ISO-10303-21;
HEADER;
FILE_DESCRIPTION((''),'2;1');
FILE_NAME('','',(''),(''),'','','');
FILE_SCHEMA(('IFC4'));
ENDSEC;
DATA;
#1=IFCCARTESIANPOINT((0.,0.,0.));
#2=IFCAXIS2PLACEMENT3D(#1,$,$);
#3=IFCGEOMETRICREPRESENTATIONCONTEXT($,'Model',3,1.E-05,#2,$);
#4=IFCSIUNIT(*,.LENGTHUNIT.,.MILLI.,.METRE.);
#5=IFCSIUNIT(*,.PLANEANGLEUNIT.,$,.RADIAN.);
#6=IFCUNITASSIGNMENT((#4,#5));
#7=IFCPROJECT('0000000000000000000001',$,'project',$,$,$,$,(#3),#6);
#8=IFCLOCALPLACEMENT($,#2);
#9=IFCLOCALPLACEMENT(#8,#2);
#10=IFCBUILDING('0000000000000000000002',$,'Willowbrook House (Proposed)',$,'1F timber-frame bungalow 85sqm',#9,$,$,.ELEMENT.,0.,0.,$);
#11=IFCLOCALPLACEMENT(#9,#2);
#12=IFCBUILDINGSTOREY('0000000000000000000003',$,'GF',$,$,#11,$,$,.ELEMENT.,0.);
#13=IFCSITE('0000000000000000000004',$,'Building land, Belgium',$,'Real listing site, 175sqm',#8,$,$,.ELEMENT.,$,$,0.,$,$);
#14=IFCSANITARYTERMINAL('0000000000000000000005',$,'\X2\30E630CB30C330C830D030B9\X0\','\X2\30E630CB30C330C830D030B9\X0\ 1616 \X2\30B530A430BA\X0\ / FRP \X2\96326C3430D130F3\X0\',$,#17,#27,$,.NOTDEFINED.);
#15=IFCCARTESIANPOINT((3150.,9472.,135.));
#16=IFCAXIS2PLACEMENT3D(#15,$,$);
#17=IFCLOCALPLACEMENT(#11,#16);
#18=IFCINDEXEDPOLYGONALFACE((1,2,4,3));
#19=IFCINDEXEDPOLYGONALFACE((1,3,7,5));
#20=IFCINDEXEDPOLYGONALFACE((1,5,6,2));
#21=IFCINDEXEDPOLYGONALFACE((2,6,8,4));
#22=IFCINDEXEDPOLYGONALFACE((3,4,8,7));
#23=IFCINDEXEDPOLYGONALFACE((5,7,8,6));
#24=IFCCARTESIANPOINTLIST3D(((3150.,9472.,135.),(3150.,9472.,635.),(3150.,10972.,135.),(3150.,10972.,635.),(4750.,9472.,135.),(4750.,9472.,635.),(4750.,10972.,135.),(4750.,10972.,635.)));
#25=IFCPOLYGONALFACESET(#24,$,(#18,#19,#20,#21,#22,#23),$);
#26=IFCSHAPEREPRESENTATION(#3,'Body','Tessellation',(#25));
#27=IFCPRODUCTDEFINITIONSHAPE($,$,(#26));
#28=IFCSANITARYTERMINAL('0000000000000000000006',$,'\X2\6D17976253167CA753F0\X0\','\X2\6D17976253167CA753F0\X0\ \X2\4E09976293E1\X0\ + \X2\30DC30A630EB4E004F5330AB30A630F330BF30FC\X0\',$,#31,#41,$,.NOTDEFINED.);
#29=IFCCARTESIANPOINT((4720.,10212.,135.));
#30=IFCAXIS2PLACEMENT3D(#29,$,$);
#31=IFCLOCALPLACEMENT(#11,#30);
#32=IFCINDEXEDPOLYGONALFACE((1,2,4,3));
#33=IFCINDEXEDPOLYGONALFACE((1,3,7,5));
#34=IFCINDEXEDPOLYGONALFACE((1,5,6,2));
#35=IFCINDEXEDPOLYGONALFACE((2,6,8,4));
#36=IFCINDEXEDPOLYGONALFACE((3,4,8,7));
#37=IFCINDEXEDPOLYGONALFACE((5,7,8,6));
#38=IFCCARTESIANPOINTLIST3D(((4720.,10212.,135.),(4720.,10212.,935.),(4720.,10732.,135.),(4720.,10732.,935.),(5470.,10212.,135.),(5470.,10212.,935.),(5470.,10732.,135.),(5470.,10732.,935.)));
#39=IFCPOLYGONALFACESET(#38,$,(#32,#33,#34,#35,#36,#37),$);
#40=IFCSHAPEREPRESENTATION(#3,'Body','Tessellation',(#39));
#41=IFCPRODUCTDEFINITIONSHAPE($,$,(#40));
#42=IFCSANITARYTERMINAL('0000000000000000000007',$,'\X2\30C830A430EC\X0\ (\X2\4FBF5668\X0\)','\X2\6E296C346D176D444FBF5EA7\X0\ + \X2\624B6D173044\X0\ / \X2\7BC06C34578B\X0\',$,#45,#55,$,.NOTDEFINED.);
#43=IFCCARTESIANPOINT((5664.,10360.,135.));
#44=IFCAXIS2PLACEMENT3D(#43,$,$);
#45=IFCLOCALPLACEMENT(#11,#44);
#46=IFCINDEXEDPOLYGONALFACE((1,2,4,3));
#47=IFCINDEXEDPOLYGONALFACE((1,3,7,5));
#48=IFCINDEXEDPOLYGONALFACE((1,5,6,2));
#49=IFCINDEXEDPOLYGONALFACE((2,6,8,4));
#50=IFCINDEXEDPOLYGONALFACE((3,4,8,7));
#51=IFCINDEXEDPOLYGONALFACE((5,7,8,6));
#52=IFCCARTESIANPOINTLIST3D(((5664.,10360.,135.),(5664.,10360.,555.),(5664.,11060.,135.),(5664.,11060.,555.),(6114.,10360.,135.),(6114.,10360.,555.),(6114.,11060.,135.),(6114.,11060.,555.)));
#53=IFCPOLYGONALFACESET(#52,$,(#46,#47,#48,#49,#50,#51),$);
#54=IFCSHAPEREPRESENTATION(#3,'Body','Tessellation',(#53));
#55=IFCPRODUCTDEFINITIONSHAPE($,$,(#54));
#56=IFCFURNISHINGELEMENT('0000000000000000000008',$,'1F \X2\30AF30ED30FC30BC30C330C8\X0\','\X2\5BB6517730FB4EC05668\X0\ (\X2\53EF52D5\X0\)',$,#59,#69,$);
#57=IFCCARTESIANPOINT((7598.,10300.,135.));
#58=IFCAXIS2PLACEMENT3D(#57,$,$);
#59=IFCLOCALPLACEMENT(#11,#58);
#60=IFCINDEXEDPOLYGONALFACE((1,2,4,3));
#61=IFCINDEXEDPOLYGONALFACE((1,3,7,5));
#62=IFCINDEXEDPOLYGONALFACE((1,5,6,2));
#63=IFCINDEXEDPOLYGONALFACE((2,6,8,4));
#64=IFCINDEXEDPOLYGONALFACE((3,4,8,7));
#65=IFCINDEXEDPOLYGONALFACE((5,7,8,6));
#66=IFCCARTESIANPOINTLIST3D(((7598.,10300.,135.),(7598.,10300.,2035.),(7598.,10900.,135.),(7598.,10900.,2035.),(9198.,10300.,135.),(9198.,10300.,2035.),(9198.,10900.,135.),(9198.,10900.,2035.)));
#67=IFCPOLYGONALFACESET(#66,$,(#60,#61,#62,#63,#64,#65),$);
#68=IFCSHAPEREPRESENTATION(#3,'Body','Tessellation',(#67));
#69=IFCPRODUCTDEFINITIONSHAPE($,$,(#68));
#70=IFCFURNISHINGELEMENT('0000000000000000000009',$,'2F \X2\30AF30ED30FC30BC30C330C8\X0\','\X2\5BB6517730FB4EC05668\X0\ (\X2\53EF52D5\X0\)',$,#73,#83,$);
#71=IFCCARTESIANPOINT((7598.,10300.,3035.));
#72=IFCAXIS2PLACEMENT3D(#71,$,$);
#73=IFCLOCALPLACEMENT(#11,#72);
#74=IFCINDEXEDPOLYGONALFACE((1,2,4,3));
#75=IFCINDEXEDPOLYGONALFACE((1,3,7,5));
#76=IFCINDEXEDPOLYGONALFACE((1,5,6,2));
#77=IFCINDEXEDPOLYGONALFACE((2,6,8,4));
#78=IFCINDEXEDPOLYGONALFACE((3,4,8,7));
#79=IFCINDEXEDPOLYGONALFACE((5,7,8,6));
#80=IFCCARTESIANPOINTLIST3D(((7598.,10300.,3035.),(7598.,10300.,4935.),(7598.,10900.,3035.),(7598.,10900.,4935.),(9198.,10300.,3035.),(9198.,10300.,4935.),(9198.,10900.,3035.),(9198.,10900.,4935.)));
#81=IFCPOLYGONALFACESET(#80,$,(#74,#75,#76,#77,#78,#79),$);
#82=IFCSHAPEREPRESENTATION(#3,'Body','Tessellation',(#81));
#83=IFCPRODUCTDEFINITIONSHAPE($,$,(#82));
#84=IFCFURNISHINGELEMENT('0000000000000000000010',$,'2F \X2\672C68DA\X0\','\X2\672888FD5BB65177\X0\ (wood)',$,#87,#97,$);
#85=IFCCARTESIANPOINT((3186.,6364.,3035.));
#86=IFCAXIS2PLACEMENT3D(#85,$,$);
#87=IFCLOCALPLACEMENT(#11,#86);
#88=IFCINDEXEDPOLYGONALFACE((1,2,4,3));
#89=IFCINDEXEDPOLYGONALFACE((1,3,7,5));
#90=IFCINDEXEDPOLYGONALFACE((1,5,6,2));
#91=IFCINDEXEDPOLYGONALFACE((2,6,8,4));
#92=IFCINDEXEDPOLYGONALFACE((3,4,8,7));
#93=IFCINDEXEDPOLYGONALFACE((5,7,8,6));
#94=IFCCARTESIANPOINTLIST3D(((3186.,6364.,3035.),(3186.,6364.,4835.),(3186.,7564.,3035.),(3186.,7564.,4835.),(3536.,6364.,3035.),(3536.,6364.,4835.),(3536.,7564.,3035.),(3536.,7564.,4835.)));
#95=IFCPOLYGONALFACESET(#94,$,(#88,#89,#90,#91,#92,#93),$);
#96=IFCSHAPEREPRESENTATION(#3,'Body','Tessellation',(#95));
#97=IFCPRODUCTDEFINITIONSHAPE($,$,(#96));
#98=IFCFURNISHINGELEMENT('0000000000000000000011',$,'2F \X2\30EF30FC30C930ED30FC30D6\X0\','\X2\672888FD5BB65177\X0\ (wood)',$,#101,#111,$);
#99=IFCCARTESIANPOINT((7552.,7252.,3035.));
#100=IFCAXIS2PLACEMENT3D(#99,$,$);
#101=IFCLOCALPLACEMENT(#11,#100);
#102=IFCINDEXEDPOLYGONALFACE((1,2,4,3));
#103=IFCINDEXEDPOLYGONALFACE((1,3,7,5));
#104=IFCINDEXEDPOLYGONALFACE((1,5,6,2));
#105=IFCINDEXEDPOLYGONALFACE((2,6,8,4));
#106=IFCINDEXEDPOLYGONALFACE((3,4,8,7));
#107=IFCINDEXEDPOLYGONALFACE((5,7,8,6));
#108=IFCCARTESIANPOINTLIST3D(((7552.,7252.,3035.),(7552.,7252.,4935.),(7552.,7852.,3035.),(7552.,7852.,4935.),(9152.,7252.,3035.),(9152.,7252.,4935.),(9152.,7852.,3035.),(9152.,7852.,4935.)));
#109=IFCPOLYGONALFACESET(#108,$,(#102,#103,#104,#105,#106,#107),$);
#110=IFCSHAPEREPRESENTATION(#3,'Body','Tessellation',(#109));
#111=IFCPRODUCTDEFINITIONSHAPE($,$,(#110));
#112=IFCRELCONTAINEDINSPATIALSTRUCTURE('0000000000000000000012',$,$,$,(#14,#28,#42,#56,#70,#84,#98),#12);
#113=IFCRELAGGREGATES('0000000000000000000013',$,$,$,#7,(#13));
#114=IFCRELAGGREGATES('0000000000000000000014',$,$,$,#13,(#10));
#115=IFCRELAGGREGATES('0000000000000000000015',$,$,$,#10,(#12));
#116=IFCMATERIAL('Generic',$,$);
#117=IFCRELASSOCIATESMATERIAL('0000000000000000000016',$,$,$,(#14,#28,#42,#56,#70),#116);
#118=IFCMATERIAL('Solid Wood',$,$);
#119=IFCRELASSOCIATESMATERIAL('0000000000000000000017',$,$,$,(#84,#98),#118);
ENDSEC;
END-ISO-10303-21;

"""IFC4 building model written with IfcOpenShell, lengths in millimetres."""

from ifc_helpers import new_model, si_unit, frame, frame_2d, origin, place, context, project, spatial, rectangle, extrude, material, element, save


model = new_model("IFC4")

# Units and contexts
model_context = context("Model", 3, precision=1e-05, world=origin())
ifc_project = project(units=[si_unit("LENGTHUNIT", "METRE", prefix="MILLI"), si_unit("PLANEANGLEUNIT", "RADIAN")], contexts=[model_context])

# Site, building, storey
site_placement = place(None, origin())
site = spatial("IfcSite", under=ifc_project, at=site_placement, Name="Building land, Belgium", ObjectType="Real listing site, 175sqm", CompositionType="ELEMENT", RefElevation=0.0)
building_placement = place(site_placement, origin())
building = spatial("IfcBuilding", under=site, at=building_placement, Name="Willowbrook House (Proposed)", ObjectType="1F timber-frame bungalow 85sqm", CompositionType="ELEMENT", ElevationOfRefHeight=0.0, ElevationOfTerrain=0.0)
storey_placement = place(building_placement, origin())
storey = spatial("IfcBuildingStorey", under=building, at=storey_placement, Name="GF", CompositionType="ELEMENT", Elevation=0.0)

# Shared definitions
ifc_material_1 = material(Name="Solid Wood")

# Shared definitions
ifc_material_2 = material(Name="Generic")

# Sanitary terminals
sanitary_terminal_1_placement = place(storey_placement, frame((3150.0, 9472.0, 135.0)))
element("IfcSanitaryTerminal", 1, at=sanitary_terminal_1_placement, inside=storey, material=ifc_material_2, Name="ユニットバス", Description="ユニットバス 1616 サイズ / FRP 防水パン", PredefinedType="NOTDEFINED", context=model_context, shape_type="SweptSolid", body=[
    extrude(rectangle(XDim=1600.0, YDim=1500.0, at=frame_2d((800.0, 750.0))), frame((3150.0, 9472.0, 135.0)), (0.0, 0.0, 1.0), 500.0),
])
sanitary_terminal_2_placement = place(storey_placement, frame((4720.0, 10212.0, 135.0)))
element("IfcSanitaryTerminal", 2, at=sanitary_terminal_2_placement, inside=storey, material=ifc_material_2, Name="洗面化粧台", Description="洗面化粧台 三面鏡 + ボウル一体カウンター", PredefinedType="NOTDEFINED", context=model_context, shape_type="SweptSolid", body=[
    extrude(rectangle(XDim=750.0, YDim=520.0, at=frame_2d((375.0, 260.0))), frame((4720.0, 10212.0, 135.0)), (0.0, 0.0, 1.0), 800.0),
])
sanitary_terminal_3_placement = place(storey_placement, frame((5664.0, 10360.0, 135.0)))
element("IfcSanitaryTerminal", 3, at=sanitary_terminal_3_placement, inside=storey, material=ifc_material_2, Name="トイレ (便器)", Description="温水洗浄便座 + 手洗い / 節水型", PredefinedType="NOTDEFINED", context=model_context, shape_type="SweptSolid", body=[
    extrude(rectangle(XDim=450.0, YDim=700.0, at=frame_2d((225.0, 350.0))), frame((5664.0, 10360.0, 135.0)), (0.0, 0.0, 1.0), 420.0),
])

# Furnishing elements
furnishing_1_placement = place(storey_placement, frame((7598.0, 10300.0, 135.0)))
element("IfcFurnishingElement", 4, at=furnishing_1_placement, inside=storey, material=ifc_material_2, Name="1F クローゼット", Description="家具・什器 (可動)", context=model_context, shape_type="SweptSolid", body=[
    extrude(rectangle(XDim=1600.0, YDim=600.0, at=frame_2d((800.0, 300.0))), frame((7598.0, 10300.0, 135.0)), (0.0, 0.0, 1.0), 1900.0),
])
furnishing_2_placement = place(storey_placement, frame((7598.0, 10300.0, 3035.0)))
element("IfcFurnishingElement", 5, at=furnishing_2_placement, inside=storey, material=ifc_material_2, Name="2F クローゼット", Description="家具・什器 (可動)", context=model_context, shape_type="SweptSolid", body=[
    extrude(rectangle(XDim=1600.0, YDim=600.0, at=frame_2d((800.0, 300.0))), frame((7598.0, 10300.0, 3035.0)), (0.0, 0.0, 1.0), 1900.0),
])
furnishing_3_placement = place(storey_placement, frame((3186.0, 6364.0, 3035.0)))
element("IfcFurnishingElement", 6, at=furnishing_3_placement, inside=storey, material=ifc_material_1, Name="2F 本棚", Description="木製家具 (wood)", context=model_context, shape_type="SweptSolid", body=[
    extrude(rectangle(XDim=350.0, YDim=1200.0, at=frame_2d((175.0, 600.0))), frame((3186.0, 6364.0, 3035.0)), (0.0, 0.0, 1.0), 1800.0),
])
furnishing_4_placement = place(storey_placement, frame((7552.0, 7252.0, 3035.0)))
element("IfcFurnishingElement", 7, at=furnishing_4_placement, inside=storey, material=ifc_material_1, Name="2F ワードローブ", Description="木製家具 (wood)", context=model_context, shape_type="SweptSolid", body=[
    extrude(rectangle(XDim=1600.0, YDim=600.0, at=frame_2d((800.0, 300.0))), frame((7552.0, 7252.0, 3035.0)), (0.0, 0.0, 1.0), 1900.0),
])

save(model, "model.ifc")
